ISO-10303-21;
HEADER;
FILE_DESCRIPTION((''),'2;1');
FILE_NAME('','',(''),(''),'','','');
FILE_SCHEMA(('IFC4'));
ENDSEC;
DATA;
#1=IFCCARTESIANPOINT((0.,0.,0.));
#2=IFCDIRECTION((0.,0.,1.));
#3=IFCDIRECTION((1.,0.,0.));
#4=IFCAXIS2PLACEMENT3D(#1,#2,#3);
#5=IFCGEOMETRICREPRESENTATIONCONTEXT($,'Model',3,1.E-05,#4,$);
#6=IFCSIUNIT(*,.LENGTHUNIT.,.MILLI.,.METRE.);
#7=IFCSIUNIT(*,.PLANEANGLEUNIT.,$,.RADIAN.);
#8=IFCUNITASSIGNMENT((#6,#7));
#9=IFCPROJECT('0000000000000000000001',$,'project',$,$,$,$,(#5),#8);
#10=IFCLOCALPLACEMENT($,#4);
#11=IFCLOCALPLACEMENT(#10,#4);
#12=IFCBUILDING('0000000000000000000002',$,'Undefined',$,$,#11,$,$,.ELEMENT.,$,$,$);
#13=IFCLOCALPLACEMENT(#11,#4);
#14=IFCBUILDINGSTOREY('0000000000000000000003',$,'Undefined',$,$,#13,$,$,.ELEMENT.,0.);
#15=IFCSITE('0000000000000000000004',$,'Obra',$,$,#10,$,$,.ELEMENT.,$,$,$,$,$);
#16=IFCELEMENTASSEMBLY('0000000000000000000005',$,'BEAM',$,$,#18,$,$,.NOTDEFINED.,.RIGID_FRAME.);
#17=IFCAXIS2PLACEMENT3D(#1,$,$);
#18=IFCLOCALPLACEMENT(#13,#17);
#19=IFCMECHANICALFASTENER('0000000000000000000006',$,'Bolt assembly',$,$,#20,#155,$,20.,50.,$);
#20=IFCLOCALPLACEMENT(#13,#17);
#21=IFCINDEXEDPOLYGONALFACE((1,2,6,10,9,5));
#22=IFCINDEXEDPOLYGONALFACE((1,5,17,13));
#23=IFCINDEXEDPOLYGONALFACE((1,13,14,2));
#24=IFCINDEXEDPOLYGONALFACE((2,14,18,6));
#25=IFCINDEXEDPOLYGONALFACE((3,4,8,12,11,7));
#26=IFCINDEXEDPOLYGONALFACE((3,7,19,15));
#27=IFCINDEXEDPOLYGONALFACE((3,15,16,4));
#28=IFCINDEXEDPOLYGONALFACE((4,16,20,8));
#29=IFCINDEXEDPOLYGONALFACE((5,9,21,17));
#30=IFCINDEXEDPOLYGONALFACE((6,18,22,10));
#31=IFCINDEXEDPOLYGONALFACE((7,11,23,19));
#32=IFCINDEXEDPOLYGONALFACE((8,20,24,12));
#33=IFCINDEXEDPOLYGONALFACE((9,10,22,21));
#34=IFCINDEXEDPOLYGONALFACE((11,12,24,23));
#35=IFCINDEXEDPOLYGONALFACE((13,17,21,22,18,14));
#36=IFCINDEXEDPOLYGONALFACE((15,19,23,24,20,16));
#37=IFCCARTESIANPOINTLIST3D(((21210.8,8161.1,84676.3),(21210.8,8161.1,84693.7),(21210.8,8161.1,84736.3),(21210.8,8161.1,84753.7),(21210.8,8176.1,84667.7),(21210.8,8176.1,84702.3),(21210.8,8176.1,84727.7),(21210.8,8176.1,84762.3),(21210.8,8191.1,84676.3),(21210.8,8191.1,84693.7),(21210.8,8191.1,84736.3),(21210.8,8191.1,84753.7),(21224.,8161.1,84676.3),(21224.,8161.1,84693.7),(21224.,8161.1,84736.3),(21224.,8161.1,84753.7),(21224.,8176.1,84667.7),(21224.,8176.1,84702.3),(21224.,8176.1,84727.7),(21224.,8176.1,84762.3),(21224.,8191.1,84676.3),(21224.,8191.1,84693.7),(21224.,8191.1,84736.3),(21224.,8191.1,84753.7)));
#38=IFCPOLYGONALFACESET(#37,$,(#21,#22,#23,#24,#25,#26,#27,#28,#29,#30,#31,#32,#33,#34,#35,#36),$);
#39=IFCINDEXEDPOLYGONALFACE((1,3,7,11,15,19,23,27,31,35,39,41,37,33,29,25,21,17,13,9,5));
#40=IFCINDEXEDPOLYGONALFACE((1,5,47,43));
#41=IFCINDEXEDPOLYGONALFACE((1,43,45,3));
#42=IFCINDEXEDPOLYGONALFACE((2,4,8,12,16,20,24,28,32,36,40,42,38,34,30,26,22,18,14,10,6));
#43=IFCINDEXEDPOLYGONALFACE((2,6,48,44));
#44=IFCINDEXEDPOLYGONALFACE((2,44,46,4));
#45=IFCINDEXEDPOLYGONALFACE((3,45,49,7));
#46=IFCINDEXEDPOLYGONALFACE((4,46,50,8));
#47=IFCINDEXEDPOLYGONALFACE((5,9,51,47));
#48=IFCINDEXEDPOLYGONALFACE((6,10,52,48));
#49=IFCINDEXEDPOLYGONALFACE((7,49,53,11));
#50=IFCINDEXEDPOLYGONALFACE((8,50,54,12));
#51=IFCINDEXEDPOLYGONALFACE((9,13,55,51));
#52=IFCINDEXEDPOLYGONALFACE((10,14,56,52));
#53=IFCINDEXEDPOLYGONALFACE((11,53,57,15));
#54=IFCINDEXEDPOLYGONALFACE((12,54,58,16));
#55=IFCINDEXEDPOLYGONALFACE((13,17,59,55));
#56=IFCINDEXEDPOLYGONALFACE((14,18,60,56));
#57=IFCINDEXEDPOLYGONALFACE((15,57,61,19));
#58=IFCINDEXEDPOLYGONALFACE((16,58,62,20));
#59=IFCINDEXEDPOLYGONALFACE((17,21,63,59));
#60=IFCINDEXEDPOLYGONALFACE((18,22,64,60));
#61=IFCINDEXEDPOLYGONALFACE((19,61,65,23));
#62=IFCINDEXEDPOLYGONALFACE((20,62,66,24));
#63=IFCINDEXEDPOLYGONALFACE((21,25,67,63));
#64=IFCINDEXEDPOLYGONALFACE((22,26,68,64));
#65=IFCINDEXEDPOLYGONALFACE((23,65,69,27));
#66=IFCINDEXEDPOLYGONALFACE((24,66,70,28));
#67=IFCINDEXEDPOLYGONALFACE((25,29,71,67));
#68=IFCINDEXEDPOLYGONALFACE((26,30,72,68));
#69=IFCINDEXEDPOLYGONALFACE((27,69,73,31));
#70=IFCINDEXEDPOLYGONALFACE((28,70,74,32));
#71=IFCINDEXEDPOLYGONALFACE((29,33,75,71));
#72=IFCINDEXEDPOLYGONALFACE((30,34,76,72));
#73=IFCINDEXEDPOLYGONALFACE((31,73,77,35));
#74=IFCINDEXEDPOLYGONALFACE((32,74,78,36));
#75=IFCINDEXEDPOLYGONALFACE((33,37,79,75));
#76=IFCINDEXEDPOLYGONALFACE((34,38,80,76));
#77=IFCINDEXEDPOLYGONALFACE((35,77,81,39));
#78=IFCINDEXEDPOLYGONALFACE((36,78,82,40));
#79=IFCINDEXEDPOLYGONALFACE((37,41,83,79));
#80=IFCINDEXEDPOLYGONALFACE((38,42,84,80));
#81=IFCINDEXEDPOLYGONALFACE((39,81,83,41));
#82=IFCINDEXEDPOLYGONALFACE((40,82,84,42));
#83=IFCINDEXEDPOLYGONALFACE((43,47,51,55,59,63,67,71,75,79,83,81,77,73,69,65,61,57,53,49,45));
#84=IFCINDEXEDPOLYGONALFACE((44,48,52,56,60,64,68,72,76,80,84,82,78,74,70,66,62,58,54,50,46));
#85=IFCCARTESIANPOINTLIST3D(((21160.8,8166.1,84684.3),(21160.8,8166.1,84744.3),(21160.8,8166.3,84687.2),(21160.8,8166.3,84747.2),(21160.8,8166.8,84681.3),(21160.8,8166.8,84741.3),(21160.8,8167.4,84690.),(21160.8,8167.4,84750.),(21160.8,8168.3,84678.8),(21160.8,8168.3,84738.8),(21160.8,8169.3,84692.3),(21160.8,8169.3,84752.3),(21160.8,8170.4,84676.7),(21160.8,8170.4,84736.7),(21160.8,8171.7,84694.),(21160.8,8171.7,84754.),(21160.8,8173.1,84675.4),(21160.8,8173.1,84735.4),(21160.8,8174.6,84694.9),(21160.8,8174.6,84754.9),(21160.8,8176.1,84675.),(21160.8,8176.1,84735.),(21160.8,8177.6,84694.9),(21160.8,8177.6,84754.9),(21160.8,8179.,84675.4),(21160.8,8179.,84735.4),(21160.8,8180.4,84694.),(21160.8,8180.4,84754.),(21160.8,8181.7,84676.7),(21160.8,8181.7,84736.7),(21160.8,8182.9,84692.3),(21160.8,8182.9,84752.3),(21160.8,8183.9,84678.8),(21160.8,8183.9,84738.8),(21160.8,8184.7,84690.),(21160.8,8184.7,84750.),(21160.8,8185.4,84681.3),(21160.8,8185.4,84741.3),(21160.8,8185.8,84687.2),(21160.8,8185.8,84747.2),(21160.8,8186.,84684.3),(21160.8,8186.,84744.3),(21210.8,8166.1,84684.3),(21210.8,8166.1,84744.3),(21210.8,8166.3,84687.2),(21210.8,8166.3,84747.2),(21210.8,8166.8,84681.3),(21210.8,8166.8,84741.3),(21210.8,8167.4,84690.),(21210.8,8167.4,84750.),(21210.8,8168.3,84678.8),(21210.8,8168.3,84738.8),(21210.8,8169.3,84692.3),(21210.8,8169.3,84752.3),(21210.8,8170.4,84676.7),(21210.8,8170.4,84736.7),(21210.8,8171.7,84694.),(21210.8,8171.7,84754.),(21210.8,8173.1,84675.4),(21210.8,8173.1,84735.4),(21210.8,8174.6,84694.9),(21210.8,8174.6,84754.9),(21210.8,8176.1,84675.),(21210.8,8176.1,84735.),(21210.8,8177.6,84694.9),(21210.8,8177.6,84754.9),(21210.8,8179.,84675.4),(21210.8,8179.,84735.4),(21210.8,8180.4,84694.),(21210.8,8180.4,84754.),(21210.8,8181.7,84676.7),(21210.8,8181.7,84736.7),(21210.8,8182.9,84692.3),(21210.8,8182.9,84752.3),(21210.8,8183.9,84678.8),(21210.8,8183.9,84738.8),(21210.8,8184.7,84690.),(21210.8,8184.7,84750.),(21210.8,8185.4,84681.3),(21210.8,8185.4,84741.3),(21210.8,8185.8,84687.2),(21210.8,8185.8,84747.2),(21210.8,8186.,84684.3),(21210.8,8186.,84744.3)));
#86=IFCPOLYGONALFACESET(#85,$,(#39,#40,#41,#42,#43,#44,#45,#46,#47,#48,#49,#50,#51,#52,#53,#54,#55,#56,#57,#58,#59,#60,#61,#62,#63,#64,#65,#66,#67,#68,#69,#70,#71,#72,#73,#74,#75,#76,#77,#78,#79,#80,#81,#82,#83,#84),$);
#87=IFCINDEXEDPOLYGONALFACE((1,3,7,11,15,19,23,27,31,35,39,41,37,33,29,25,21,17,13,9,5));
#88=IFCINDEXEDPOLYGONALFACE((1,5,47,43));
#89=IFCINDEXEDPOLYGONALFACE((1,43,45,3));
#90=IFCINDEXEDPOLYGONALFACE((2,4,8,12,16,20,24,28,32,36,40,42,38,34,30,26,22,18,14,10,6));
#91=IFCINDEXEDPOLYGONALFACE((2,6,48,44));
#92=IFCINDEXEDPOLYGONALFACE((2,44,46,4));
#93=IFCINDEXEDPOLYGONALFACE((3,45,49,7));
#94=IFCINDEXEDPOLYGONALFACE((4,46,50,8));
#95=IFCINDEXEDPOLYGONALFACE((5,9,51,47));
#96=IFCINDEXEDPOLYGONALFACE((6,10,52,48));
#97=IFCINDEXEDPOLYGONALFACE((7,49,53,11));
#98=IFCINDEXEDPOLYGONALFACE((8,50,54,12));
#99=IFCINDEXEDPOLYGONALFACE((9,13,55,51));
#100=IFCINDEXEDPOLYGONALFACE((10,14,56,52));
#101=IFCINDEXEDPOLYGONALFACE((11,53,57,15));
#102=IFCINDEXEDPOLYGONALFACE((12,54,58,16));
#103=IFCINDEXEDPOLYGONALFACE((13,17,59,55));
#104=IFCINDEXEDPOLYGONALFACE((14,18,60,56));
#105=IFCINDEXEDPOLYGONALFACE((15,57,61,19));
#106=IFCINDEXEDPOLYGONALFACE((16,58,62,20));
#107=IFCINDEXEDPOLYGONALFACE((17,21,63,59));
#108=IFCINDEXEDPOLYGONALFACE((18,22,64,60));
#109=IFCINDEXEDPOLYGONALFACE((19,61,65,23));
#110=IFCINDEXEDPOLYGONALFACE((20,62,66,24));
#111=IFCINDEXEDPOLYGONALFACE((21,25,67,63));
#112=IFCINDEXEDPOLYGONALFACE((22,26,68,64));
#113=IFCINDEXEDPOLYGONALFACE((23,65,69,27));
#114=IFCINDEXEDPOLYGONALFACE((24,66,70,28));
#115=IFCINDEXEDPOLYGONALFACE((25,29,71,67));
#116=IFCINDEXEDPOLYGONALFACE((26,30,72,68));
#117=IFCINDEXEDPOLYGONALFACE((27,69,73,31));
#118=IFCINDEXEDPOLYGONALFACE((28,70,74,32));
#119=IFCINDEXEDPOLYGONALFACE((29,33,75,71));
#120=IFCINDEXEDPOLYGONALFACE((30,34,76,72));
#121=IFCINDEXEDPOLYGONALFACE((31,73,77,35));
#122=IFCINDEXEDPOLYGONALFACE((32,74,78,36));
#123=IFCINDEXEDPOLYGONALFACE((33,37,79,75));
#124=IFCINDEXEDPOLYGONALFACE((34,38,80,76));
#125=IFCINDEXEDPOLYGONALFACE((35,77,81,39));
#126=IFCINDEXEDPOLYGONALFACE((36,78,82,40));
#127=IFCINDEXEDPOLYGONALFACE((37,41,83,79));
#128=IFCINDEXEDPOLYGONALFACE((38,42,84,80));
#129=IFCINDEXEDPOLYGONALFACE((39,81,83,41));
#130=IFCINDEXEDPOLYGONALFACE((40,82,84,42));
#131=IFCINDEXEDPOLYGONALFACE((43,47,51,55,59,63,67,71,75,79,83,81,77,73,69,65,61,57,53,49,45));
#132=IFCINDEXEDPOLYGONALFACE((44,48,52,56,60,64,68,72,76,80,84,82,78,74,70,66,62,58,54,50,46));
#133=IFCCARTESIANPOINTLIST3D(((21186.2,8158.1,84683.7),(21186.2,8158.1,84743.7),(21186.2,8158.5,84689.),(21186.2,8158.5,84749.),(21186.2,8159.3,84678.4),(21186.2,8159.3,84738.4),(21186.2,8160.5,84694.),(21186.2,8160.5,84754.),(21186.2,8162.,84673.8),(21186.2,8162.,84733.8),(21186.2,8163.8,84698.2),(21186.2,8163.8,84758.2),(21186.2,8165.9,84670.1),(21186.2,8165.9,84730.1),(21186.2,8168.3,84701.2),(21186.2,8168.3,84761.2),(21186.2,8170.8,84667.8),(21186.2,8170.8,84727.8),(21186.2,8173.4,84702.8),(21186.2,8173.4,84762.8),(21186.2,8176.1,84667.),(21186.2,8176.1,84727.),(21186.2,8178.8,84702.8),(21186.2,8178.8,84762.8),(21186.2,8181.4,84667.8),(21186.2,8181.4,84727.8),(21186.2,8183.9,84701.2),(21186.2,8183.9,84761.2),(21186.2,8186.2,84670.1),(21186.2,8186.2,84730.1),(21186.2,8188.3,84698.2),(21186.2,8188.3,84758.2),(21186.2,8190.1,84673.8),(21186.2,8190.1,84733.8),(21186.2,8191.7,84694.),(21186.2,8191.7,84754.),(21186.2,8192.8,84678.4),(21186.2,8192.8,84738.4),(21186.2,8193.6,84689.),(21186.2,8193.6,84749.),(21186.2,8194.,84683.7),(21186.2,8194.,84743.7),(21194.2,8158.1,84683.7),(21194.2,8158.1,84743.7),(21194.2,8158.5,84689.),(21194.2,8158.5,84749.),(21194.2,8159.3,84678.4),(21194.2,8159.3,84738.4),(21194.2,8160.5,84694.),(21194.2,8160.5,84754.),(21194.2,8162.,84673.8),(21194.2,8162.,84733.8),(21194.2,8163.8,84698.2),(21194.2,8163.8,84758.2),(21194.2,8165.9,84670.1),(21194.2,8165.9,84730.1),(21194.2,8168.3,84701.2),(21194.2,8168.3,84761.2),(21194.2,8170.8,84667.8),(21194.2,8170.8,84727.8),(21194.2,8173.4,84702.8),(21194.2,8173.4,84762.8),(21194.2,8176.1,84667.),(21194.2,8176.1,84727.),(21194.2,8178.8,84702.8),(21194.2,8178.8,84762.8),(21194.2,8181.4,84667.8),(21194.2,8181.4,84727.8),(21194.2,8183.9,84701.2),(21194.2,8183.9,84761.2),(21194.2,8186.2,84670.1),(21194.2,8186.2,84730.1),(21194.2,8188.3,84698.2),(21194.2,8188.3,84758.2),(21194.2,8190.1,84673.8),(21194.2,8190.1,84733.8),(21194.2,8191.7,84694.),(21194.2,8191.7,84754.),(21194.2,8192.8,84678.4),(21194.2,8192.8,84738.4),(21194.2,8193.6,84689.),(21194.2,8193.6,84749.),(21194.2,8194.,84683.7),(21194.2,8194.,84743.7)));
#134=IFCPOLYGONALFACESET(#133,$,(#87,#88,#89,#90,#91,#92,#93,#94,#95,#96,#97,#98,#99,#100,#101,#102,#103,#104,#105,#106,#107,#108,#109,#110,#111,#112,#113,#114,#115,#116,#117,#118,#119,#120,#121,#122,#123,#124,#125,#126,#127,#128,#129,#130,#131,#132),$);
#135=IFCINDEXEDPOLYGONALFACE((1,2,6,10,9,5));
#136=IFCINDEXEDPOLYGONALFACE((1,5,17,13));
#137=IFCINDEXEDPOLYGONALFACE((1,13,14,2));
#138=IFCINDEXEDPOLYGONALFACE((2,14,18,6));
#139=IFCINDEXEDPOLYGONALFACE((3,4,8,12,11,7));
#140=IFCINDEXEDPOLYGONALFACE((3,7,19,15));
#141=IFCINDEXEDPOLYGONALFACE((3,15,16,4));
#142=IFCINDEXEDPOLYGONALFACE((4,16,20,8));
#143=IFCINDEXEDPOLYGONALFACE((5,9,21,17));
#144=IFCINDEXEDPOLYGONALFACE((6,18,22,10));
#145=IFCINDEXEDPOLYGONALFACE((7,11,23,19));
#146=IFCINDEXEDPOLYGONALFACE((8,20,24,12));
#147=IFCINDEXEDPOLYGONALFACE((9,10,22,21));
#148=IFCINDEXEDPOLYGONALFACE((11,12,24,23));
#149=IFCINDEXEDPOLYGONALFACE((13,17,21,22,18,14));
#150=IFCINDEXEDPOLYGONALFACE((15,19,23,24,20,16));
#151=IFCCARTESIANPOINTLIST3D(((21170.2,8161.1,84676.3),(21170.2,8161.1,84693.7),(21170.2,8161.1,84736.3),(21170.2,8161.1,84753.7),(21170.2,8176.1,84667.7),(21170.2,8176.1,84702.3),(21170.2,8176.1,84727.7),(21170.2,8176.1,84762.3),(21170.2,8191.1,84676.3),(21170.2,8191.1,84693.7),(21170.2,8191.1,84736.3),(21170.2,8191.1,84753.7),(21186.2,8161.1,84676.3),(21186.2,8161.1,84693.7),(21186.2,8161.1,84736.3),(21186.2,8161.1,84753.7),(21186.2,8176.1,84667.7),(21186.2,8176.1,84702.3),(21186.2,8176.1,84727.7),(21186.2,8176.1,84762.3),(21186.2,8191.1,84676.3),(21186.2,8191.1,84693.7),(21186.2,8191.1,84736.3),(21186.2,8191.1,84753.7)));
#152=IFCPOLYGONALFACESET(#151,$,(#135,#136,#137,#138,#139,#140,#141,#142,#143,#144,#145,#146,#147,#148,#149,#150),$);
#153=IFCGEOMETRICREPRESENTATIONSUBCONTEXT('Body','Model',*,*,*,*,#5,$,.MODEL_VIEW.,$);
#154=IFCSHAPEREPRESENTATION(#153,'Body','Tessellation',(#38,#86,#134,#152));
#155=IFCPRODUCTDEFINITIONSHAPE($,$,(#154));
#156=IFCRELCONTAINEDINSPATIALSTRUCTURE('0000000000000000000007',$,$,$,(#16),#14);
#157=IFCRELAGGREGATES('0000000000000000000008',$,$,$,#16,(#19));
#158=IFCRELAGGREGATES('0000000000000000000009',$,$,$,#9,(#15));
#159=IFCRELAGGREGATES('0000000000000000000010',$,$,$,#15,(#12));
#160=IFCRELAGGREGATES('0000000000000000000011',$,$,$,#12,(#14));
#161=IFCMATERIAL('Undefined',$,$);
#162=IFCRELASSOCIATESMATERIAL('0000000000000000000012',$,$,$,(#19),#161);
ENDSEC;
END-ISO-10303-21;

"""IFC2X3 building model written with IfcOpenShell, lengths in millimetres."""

from ifc_helpers import new_model, si_unit, frame, origin_with_axes, origin_2d_with_axis, place, context, subcontext, project, spatial, polyline, circle, outline, extrude, source, transform, mapped, material, element, aggregate, save


model = new_model("IFC2X3")

# Units and contexts
model_context = context("Model", 3, precision=1e-05, world=origin_with_axes())
body_context = subcontext(model_context, "Body", "Model", "MODEL_VIEW")
ifc_project = project(units=[si_unit("LENGTHUNIT", "METRE", prefix="MILLI"), si_unit("PLANEANGLEUNIT", "RADIAN")], contexts=[model_context])

# Site, building, storey
site_placement = place(None, origin_with_axes())
site = spatial("IfcSite", under=ifc_project, at=site_placement, Name="Obra", CompositionType="ELEMENT")
building_placement = place(site_placement, origin_with_axes())
building = spatial("IfcBuilding", under=site, at=building_placement, Name="Undefined", CompositionType="ELEMENT")
storey_placement = place(building_placement, origin_with_axes())
storey = spatial("IfcBuildingStorey", under=building, at=storey_placement, Name="Undefined", CompositionType="ELEMENT", Elevation=0.0)

# Element assembly, mechanical fastener
ifc_material_1 = material(Name="Undefined")
assembly_1_placement = place(storey_placement, origin_with_axes())
assembly_1 = element("IfcElementAssembly", 1, at=assembly_1_placement, inside=storey, Name="BEAM", AssemblyPlace="NOTDEFINED", PredefinedType="RIGID_FRAME")
shared_shape_1 = source(origin_with_axes(), body_context, "Body", "SweptSolid", [
    extrude(outline(polyline([(17.3, 0.0), (8.7, 15.0), (-8.7, 15.0), (-17.3, 0.0), (-8.7, -15.0), (8.7, -15.0), (17.3, 0.0)])), frame((0.0, -26.5, 0.0), z_axis=(0.0, 1.0, 0.0), x_axis=(1.0, 0.0, 0.0)), (0.0, 0.0, 1.0), 13.2),
    extrude(circle(Radius=10.0, at=origin_2d_with_axis()), frame((0.0, -13.3, 0.0), z_axis=(0.0, 1.0, 0.0), x_axis=(1.0, 0.0, 0.0)), (0.0, 0.0, 1.0), 50.0),
    extrude(circle(Radius=18.0, at=origin_2d_with_axis()), frame((0.0, 3.3, 0.0), z_axis=(0.0, 1.0, 0.0), x_axis=(1.0, 0.0, 0.0)), (0.0, 0.0, 1.0), 8.0),
    extrude(outline(polyline([(17.3, 0.0), (8.7, 15.0), (-8.7, 15.0), (-17.3, 0.0), (-8.7, -15.0), (8.7, -15.0), (17.3, 0.0)])), frame((0.0, 11.3, 0.0), z_axis=(0.0, 1.0, 0.0), x_axis=(1.0, 0.0, 0.0)), (0.0, 0.0, 1.0), 16.0),
])
mechanical_fastener_1_placement = place(assembly_1_placement, frame((21197.5, 8136.1, 84850.0), z_axis=(0.0, 1.0, 0.0), x_axis=(0.0, 0.0, -1.0)))
mechanical_fastener_1 = element("IfcMechanicalFastener", 2, at=mechanical_fastener_1_placement, material=ifc_material_1, Name="Bolt assembly", NominalDiameter=20.0, NominalLength=50.0, context=body_context, shape_type="MappedRepresentation", body=[
    mapped(shared_shape_1, transform((105.0, 0.0, 40.0))),
    mapped(shared_shape_1, transform((165.0, 0.0, 40.0))),
])
aggregate(assembly_1, [mechanical_fastener_1])

save(model, "model.ifc")
